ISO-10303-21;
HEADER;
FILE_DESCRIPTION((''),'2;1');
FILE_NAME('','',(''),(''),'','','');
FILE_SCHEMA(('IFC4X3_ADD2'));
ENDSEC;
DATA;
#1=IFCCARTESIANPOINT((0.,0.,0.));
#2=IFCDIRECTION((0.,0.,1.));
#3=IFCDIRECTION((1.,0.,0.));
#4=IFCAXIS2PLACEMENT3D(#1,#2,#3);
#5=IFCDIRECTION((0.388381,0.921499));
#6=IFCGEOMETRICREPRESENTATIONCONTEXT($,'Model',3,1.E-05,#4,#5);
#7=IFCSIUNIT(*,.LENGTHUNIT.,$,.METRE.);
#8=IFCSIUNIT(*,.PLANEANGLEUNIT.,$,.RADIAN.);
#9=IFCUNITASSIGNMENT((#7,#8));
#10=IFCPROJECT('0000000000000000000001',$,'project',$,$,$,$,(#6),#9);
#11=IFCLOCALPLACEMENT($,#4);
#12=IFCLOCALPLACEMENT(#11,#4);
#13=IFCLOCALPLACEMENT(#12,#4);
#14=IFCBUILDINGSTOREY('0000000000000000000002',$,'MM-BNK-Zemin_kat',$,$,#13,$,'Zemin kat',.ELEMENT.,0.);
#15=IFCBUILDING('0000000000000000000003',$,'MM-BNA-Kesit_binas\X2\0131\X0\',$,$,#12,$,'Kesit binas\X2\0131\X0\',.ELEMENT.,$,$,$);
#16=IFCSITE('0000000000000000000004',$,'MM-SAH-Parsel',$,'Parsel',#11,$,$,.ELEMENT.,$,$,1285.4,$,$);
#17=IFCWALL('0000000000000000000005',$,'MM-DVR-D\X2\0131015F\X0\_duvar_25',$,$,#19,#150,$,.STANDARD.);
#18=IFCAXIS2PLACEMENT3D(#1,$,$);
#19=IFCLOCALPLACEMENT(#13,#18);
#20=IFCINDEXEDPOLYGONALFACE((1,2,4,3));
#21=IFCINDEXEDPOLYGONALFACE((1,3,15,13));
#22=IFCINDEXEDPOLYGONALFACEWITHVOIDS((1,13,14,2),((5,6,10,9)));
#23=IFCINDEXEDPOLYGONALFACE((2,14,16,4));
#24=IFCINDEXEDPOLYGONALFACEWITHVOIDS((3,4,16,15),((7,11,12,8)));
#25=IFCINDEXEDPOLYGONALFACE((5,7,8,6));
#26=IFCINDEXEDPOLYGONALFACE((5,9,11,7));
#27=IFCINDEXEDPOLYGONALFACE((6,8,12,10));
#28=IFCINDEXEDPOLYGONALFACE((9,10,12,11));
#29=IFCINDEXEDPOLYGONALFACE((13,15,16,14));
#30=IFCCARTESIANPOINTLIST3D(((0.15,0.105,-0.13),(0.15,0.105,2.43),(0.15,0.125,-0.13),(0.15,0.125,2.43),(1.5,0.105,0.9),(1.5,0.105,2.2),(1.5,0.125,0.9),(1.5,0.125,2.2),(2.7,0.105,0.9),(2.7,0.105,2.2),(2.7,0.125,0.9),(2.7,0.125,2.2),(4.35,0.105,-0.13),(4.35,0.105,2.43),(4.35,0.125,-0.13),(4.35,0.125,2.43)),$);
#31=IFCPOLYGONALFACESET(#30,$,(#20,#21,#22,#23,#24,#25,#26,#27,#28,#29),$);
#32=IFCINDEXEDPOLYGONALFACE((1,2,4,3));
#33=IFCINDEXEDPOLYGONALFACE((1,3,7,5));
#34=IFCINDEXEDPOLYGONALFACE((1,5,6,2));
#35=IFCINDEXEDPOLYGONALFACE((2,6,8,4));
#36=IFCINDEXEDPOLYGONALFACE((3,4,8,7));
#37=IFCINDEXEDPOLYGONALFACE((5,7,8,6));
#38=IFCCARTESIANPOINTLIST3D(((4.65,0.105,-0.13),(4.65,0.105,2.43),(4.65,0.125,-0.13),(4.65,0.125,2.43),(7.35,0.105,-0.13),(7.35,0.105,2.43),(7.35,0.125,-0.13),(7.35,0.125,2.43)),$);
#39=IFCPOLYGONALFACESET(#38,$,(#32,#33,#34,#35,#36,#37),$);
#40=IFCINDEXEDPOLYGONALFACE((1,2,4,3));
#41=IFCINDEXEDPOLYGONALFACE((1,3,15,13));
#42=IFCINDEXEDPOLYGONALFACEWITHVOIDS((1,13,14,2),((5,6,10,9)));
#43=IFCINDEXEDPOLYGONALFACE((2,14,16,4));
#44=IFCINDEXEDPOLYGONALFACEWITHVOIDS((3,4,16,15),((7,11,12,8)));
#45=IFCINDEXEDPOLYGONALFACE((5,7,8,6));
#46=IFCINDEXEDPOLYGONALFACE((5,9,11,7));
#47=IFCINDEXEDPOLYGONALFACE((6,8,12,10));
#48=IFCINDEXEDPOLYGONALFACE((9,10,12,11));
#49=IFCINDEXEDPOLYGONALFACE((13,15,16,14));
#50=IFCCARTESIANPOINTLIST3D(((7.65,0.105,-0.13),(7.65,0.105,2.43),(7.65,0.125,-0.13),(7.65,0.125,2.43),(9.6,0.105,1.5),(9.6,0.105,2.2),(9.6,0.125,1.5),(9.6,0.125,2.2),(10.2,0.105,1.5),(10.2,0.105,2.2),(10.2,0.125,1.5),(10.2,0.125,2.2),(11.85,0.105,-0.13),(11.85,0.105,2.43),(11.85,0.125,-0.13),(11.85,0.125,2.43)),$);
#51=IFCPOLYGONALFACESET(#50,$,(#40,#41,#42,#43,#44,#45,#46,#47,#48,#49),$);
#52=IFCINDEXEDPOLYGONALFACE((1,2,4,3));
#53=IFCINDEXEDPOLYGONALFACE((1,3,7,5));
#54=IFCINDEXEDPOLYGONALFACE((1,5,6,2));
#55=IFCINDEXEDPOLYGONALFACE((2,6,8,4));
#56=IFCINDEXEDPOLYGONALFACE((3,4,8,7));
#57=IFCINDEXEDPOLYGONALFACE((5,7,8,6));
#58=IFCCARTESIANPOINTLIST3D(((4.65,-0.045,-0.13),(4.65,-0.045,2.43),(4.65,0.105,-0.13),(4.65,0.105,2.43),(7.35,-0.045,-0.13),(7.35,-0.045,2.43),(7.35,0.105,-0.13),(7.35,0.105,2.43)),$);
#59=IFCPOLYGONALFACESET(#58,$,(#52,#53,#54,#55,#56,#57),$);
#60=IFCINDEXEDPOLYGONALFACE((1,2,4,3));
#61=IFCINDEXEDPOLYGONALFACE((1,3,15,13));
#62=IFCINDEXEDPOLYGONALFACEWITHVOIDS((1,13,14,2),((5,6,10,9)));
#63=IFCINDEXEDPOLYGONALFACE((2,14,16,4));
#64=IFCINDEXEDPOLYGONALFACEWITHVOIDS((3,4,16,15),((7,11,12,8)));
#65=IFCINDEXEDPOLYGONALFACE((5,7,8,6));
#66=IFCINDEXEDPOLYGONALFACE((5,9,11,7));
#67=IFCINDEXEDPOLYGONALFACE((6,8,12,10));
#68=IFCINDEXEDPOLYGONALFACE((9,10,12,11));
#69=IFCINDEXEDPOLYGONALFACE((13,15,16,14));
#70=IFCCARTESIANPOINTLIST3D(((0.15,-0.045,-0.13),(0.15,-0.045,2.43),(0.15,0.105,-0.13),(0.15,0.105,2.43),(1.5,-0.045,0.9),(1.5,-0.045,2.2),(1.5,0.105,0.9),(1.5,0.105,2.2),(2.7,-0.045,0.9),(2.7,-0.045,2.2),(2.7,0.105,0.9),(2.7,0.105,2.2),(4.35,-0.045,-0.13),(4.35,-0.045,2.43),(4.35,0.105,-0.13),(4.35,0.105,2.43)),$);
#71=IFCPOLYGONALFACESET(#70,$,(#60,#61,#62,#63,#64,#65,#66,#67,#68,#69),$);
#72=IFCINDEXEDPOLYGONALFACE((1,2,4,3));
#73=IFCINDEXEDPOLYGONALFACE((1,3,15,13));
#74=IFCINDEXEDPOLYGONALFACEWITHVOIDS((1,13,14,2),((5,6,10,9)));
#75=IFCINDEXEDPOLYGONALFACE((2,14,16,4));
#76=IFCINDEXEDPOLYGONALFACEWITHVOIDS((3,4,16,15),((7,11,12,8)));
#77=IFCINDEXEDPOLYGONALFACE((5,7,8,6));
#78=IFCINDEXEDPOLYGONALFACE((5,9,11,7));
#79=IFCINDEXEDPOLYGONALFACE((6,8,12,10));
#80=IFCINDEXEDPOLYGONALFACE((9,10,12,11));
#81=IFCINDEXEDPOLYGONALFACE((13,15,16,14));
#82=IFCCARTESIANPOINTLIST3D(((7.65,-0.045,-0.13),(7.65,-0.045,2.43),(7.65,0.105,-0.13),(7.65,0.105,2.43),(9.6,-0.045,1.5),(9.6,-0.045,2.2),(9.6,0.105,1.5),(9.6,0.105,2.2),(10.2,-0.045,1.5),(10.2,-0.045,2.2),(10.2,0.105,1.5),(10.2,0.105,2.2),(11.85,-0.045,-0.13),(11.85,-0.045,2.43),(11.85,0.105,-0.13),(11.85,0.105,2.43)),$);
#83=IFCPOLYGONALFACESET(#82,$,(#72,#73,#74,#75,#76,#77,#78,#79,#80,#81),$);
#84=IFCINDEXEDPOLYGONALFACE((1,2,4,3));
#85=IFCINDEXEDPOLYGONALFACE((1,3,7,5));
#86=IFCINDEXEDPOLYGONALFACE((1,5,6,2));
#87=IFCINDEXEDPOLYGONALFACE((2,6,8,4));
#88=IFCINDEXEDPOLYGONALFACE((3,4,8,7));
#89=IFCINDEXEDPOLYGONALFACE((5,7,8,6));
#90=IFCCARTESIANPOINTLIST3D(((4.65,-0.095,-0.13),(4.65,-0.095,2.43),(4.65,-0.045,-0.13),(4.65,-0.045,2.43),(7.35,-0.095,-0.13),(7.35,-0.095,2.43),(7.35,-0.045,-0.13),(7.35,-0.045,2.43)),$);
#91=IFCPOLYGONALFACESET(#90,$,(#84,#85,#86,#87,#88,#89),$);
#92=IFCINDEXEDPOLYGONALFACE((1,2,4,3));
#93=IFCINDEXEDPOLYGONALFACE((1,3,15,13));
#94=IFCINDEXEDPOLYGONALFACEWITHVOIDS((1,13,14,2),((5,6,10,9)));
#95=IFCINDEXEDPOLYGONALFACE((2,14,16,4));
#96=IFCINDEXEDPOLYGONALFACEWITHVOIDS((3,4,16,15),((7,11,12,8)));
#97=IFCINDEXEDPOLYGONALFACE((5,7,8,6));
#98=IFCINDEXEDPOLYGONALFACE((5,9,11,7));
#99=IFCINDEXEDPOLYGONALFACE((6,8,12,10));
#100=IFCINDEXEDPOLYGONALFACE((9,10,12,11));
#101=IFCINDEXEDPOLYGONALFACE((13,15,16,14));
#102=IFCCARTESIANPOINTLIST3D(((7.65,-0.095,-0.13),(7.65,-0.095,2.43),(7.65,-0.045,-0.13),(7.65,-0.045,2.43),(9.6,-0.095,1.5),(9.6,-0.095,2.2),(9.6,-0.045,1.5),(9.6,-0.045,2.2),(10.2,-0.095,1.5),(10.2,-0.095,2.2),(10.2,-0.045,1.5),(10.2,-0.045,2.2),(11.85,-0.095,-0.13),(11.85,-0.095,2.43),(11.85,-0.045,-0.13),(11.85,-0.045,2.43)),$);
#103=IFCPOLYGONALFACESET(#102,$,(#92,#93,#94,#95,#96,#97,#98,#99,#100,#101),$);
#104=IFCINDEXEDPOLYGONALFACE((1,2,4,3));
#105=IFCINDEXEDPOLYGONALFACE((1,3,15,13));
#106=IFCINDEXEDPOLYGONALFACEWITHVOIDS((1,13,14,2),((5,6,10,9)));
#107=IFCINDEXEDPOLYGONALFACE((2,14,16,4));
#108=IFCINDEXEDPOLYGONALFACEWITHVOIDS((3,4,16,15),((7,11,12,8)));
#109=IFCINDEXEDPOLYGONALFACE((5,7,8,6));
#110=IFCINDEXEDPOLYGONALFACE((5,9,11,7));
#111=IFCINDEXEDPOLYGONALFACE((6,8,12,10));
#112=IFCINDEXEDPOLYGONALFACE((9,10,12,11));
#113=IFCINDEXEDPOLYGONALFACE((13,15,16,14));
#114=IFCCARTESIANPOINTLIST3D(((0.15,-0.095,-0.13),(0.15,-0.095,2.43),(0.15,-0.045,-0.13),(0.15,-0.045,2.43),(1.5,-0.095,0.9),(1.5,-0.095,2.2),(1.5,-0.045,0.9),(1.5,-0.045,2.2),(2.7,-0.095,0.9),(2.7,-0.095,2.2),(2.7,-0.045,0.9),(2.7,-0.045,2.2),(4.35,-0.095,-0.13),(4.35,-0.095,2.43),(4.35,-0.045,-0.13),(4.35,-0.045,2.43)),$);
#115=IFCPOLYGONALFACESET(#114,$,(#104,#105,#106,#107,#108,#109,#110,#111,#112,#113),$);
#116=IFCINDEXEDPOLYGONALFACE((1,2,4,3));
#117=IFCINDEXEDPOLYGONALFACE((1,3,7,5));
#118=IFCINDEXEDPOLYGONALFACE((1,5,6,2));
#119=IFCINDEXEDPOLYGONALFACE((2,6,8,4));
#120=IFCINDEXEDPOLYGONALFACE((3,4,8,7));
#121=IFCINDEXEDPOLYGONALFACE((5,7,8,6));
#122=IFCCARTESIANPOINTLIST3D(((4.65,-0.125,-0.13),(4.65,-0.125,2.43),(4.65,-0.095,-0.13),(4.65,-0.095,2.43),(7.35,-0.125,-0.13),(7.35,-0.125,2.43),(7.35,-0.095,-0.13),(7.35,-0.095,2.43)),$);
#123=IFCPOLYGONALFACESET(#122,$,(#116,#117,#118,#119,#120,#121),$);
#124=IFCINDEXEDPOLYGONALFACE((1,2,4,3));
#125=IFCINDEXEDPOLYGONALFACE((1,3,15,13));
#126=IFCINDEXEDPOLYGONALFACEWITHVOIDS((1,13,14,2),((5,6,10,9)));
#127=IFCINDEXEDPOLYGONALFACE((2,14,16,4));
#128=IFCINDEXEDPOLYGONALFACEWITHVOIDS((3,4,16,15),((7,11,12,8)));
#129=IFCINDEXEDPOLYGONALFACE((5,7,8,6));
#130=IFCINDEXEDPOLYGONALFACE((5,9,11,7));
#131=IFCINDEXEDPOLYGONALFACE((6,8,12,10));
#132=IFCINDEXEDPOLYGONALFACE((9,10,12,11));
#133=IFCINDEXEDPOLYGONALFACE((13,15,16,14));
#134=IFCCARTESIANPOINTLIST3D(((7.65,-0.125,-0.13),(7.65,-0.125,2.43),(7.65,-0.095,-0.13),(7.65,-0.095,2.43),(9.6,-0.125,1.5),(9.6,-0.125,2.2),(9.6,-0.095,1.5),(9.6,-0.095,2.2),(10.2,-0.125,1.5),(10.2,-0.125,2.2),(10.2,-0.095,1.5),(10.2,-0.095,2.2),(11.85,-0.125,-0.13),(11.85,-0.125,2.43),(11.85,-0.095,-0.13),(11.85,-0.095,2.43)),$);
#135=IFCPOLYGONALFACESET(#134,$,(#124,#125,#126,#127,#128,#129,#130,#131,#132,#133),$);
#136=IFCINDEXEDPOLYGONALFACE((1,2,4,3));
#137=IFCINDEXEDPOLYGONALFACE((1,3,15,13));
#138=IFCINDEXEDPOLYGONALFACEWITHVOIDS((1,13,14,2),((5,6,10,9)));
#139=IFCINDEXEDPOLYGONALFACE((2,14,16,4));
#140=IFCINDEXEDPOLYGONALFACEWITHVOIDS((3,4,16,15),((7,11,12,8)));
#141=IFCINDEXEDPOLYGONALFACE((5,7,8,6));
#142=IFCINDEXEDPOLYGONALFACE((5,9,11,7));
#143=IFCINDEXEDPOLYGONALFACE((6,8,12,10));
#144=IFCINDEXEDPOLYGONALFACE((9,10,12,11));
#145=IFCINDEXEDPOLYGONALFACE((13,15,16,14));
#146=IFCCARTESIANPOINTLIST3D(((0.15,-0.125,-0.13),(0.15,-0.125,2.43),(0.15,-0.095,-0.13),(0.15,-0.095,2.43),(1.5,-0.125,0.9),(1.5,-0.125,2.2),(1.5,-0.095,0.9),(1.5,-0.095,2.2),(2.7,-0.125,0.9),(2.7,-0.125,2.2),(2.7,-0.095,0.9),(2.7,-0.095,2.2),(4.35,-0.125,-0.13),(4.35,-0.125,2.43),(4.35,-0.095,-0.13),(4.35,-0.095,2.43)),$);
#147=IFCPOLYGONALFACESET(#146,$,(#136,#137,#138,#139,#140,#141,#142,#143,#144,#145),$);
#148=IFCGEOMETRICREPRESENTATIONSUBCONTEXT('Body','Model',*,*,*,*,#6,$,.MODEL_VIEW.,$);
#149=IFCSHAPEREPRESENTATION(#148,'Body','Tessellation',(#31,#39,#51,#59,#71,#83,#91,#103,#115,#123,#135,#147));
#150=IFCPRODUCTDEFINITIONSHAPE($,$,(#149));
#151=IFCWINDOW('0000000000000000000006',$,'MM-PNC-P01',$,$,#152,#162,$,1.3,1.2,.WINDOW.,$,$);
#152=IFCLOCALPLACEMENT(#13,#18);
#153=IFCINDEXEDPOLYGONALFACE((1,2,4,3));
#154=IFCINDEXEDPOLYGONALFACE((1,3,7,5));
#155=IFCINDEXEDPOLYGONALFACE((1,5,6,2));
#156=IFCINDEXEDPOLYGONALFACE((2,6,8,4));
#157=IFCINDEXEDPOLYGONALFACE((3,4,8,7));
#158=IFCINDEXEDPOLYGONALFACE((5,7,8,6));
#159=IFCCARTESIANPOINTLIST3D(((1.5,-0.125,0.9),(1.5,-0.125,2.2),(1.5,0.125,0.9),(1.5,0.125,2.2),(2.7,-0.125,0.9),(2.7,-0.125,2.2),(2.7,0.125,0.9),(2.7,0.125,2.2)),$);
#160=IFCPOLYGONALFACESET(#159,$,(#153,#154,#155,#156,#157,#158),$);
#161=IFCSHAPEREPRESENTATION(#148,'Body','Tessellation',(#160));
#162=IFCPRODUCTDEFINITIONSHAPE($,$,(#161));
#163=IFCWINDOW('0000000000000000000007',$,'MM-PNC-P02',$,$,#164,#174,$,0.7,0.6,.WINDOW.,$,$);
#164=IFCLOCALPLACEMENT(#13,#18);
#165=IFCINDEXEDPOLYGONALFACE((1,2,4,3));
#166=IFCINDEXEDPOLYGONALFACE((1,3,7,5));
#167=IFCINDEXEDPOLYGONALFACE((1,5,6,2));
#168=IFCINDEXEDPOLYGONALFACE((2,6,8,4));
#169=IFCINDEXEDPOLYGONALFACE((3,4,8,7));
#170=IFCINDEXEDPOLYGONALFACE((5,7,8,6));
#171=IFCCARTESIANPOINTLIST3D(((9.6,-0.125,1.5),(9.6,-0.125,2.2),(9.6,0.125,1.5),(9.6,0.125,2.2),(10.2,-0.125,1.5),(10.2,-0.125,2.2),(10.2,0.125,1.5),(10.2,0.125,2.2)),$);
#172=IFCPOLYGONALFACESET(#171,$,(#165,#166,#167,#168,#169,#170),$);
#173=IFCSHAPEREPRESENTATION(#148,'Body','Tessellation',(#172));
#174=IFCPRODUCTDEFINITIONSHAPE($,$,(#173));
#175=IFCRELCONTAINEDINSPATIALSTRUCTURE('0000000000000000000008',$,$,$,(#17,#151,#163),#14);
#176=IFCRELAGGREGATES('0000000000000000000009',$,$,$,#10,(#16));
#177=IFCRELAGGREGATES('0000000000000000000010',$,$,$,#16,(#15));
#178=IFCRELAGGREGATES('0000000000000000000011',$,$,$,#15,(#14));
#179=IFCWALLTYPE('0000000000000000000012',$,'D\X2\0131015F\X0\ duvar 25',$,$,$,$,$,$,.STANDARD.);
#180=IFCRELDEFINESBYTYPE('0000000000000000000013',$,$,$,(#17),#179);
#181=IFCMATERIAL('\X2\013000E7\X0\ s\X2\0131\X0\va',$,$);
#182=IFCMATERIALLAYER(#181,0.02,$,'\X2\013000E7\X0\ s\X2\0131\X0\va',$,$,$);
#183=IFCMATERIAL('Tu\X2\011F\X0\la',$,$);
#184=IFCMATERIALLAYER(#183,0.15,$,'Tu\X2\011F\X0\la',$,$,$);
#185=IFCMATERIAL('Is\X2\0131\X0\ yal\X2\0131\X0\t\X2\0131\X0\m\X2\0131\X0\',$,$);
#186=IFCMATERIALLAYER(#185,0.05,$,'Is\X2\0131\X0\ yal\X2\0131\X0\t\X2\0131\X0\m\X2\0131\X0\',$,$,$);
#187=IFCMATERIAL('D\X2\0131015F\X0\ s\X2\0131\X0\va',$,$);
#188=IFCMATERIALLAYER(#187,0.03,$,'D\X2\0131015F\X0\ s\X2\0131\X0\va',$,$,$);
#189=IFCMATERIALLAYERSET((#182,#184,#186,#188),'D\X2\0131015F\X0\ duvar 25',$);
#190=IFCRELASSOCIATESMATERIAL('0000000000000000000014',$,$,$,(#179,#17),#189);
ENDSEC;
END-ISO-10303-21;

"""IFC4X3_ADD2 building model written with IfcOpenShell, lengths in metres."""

from ifc_helpers import new_model, si_unit, direction, frame, origin_with_axes, place, context, subcontext, project, spatial, polyline, outline, extrude, material, layer, layer_set, type_object, element, fill, save


model = new_model("IFC4X3_ADD2")

# Units and contexts
model_context = context("Model", 3, precision=1e-05, world=origin_with_axes(), true_north=direction((0.388381, 0.921499)))
body_context = subcontext(model_context, "Body", "Model", "MODEL_VIEW")
ifc_project = project(units=[si_unit("LENGTHUNIT", "METRE"), si_unit("PLANEANGLEUNIT", "RADIAN")], contexts=[model_context])

# Site, building, storey
site_placement = place(None, origin_with_axes())
site = spatial("IfcSite", under=ifc_project, at=site_placement, Name="MM-SAH-Parsel", ObjectType="Parsel", CompositionType="ELEMENT", RefElevation=1285.4)
building_placement = place(site_placement, origin_with_axes())
building = spatial("IfcBuilding", under=site, at=building_placement, Name="MM-BNA-Kesit_binası", LongName="Kesit binası", CompositionType="ELEMENT")
storey_placement = place(building_placement, origin_with_axes())
storey = spatial("IfcBuildingStorey", under=building, at=storey_placement, Name="MM-BNK-Zemin_kat", LongName="Zemin kat", CompositionType="ELEMENT", Elevation=0.0)

# Wall, openings, windows
ifc_material_1 = material(Name="İç sıva")
ifc_layer_1 = layer(ifc_material_1, 0.02, Name="İç sıva")
ifc_material_2 = material(Name="Tuğla")
ifc_layer_2 = layer(ifc_material_2, 0.15, Name="Tuğla")
ifc_material_3 = material(Name="Isı yalıtımı")
ifc_layer_3 = layer(ifc_material_3, 0.05, Name="Isı yalıtımı")
ifc_material_4 = material(Name="Dış sıva")
ifc_layer_4 = layer(ifc_material_4, 0.03, Name="Dış sıva")
ifc_layer_set_1 = layer_set([ifc_layer_1, ifc_layer_2, ifc_layer_3, ifc_layer_4], Name="Dış duvar 25")
wall_type_1 = type_object("IfcWallType", Name="Dış duvar 25", PredefinedType="STANDARD", material=ifc_layer_set_1)
wall_1_placement = place(storey_placement, origin_with_axes())
wall_1 = element("IfcWall", 1, at=wall_1_placement, inside=storey, type_object=wall_type_1, material=ifc_layer_set_1, Name="MM-DVR-Dış_duvar_25", PredefinedType="STANDARD", context=body_context, shape_type="SweptSolid", body=[
    extrude(outline(polyline([(0.15, 0.105), (4.35, 0.105), (4.35, 0.125), (0.15, 0.125), (0.15, 0.105)])), frame((0.0, 0.0, -0.13)), (0.0, 0.0, 1.0), 2.56),
    extrude(outline(polyline([(4.65, 0.105), (7.35, 0.105), (7.35, 0.125), (4.65, 0.125), (4.65, 0.105)])), frame((0.0, 0.0, -0.13)), (0.0, 0.0, 1.0), 2.56),
    extrude(outline(polyline([(7.65, 0.105), (11.85, 0.105), (11.85, 0.125), (7.65, 0.125), (7.65, 0.105)])), frame((0.0, 0.0, -0.13)), (0.0, 0.0, 1.0), 2.56),
    extrude(outline(polyline([(4.65, -0.045), (7.35, -0.045), (7.35, 0.105), (4.65, 0.105), (4.65, -0.045)])), frame((0.0, 0.0, -0.13)), (0.0, 0.0, 1.0), 2.56),
    extrude(outline(polyline([(0.15, -0.045), (4.35, -0.045), (4.35, 0.105), (0.15, 0.105), (0.15, -0.045)])), frame((0.0, 0.0, -0.13)), (0.0, 0.0, 1.0), 2.56),
    extrude(outline(polyline([(7.65, -0.045), (11.85, -0.045), (11.85, 0.105), (7.65, 0.105), (7.65, -0.045)])), frame((0.0, 0.0, -0.13)), (0.0, 0.0, 1.0), 2.56),
    extrude(outline(polyline([(4.65, -0.095), (7.35, -0.095), (7.35, -0.045), (4.65, -0.045), (4.65, -0.095)])), frame((0.0, 0.0, -0.13)), (0.0, 0.0, 1.0), 2.56),
    extrude(outline(polyline([(7.65, -0.095), (11.85, -0.095), (11.85, -0.045), (7.65, -0.045), (7.65, -0.095)])), frame((0.0, 0.0, -0.13)), (0.0, 0.0, 1.0), 2.56),
    extrude(outline(polyline([(0.15, -0.095), (4.35, -0.095), (4.35, -0.045), (0.15, -0.045), (0.15, -0.095)])), frame((0.0, 0.0, -0.13)), (0.0, 0.0, 1.0), 2.56),
    extrude(outline(polyline([(4.65, -0.125), (7.35, -0.125), (7.35, -0.095), (4.65, -0.095), (4.65, -0.125)])), frame((0.0, 0.0, -0.13)), (0.0, 0.0, 1.0), 2.56),
    extrude(outline(polyline([(7.65, -0.125), (11.85, -0.125), (11.85, -0.095), (7.65, -0.095), (7.65, -0.125)])), frame((0.0, 0.0, -0.13)), (0.0, 0.0, 1.0), 2.56),
    extrude(outline(polyline([(0.15, -0.125), (4.35, -0.125), (4.35, -0.095), (0.15, -0.095), (0.15, -0.125)])), frame((0.0, 0.0, -0.13)), (0.0, 0.0, 1.0), 2.56),
])
opening_1_placement = place(storey_placement, origin_with_axes())
opening_1 = element("IfcOpeningElement", 2, at=opening_1_placement, cuts=wall_1, PredefinedType="OPENING", context=body_context, shape_type="SweptSolid", body=[
    extrude(outline(polyline([(1.5, 0.125), (2.7, 0.125), (2.7, -0.125), (1.5, -0.125), (1.5, 0.125)])), frame((0.0, 0.0, 0.9)), (0.0, 0.0, 1.0), 1.3),
])
opening_2_placement = place(storey_placement, origin_with_axes())
opening_2 = element("IfcOpeningElement", 3, at=opening_2_placement, cuts=wall_1, PredefinedType="OPENING", context=body_context, shape_type="SweptSolid", body=[
    extrude(outline(polyline([(9.6, 0.125), (10.2, 0.125), (10.2, -0.125), (9.6, -0.125), (9.6, 0.125)])), frame((0.0, 0.0, 1.5)), (0.0, 0.0, 1.0), 0.7),
])
window_1_placement = place(storey_placement, origin_with_axes())
window_1 = element("IfcWindow", 4, at=window_1_placement, inside=storey, Name="MM-PNC-P01", OverallHeight=1.3, OverallWidth=1.2, PredefinedType="WINDOW", context=body_context, shape_type="SweptSolid", body=[
    extrude(outline(polyline([(1.5, 0.125), (2.7, 0.125), (2.7, -0.125), (1.5, -0.125), (1.5, 0.125)])), frame((0.0, 0.0, 0.9)), (0.0, 0.0, 1.0), 1.3),
])
fill(opening_1, window_1)
window_2_placement = place(storey_placement, origin_with_axes())
window_2 = element("IfcWindow", 5, at=window_2_placement, inside=storey, Name="MM-PNC-P02", OverallHeight=0.7, OverallWidth=0.6, PredefinedType="WINDOW", context=body_context, shape_type="SweptSolid", body=[
    extrude(outline(polyline([(9.6, 0.125), (10.2, 0.125), (10.2, -0.125), (9.6, -0.125), (9.6, 0.125)])), frame((0.0, 0.0, 1.5)), (0.0, 0.0, 1.0), 0.7),
])
fill(opening_2, window_2)

save(model, "model.ifc")
